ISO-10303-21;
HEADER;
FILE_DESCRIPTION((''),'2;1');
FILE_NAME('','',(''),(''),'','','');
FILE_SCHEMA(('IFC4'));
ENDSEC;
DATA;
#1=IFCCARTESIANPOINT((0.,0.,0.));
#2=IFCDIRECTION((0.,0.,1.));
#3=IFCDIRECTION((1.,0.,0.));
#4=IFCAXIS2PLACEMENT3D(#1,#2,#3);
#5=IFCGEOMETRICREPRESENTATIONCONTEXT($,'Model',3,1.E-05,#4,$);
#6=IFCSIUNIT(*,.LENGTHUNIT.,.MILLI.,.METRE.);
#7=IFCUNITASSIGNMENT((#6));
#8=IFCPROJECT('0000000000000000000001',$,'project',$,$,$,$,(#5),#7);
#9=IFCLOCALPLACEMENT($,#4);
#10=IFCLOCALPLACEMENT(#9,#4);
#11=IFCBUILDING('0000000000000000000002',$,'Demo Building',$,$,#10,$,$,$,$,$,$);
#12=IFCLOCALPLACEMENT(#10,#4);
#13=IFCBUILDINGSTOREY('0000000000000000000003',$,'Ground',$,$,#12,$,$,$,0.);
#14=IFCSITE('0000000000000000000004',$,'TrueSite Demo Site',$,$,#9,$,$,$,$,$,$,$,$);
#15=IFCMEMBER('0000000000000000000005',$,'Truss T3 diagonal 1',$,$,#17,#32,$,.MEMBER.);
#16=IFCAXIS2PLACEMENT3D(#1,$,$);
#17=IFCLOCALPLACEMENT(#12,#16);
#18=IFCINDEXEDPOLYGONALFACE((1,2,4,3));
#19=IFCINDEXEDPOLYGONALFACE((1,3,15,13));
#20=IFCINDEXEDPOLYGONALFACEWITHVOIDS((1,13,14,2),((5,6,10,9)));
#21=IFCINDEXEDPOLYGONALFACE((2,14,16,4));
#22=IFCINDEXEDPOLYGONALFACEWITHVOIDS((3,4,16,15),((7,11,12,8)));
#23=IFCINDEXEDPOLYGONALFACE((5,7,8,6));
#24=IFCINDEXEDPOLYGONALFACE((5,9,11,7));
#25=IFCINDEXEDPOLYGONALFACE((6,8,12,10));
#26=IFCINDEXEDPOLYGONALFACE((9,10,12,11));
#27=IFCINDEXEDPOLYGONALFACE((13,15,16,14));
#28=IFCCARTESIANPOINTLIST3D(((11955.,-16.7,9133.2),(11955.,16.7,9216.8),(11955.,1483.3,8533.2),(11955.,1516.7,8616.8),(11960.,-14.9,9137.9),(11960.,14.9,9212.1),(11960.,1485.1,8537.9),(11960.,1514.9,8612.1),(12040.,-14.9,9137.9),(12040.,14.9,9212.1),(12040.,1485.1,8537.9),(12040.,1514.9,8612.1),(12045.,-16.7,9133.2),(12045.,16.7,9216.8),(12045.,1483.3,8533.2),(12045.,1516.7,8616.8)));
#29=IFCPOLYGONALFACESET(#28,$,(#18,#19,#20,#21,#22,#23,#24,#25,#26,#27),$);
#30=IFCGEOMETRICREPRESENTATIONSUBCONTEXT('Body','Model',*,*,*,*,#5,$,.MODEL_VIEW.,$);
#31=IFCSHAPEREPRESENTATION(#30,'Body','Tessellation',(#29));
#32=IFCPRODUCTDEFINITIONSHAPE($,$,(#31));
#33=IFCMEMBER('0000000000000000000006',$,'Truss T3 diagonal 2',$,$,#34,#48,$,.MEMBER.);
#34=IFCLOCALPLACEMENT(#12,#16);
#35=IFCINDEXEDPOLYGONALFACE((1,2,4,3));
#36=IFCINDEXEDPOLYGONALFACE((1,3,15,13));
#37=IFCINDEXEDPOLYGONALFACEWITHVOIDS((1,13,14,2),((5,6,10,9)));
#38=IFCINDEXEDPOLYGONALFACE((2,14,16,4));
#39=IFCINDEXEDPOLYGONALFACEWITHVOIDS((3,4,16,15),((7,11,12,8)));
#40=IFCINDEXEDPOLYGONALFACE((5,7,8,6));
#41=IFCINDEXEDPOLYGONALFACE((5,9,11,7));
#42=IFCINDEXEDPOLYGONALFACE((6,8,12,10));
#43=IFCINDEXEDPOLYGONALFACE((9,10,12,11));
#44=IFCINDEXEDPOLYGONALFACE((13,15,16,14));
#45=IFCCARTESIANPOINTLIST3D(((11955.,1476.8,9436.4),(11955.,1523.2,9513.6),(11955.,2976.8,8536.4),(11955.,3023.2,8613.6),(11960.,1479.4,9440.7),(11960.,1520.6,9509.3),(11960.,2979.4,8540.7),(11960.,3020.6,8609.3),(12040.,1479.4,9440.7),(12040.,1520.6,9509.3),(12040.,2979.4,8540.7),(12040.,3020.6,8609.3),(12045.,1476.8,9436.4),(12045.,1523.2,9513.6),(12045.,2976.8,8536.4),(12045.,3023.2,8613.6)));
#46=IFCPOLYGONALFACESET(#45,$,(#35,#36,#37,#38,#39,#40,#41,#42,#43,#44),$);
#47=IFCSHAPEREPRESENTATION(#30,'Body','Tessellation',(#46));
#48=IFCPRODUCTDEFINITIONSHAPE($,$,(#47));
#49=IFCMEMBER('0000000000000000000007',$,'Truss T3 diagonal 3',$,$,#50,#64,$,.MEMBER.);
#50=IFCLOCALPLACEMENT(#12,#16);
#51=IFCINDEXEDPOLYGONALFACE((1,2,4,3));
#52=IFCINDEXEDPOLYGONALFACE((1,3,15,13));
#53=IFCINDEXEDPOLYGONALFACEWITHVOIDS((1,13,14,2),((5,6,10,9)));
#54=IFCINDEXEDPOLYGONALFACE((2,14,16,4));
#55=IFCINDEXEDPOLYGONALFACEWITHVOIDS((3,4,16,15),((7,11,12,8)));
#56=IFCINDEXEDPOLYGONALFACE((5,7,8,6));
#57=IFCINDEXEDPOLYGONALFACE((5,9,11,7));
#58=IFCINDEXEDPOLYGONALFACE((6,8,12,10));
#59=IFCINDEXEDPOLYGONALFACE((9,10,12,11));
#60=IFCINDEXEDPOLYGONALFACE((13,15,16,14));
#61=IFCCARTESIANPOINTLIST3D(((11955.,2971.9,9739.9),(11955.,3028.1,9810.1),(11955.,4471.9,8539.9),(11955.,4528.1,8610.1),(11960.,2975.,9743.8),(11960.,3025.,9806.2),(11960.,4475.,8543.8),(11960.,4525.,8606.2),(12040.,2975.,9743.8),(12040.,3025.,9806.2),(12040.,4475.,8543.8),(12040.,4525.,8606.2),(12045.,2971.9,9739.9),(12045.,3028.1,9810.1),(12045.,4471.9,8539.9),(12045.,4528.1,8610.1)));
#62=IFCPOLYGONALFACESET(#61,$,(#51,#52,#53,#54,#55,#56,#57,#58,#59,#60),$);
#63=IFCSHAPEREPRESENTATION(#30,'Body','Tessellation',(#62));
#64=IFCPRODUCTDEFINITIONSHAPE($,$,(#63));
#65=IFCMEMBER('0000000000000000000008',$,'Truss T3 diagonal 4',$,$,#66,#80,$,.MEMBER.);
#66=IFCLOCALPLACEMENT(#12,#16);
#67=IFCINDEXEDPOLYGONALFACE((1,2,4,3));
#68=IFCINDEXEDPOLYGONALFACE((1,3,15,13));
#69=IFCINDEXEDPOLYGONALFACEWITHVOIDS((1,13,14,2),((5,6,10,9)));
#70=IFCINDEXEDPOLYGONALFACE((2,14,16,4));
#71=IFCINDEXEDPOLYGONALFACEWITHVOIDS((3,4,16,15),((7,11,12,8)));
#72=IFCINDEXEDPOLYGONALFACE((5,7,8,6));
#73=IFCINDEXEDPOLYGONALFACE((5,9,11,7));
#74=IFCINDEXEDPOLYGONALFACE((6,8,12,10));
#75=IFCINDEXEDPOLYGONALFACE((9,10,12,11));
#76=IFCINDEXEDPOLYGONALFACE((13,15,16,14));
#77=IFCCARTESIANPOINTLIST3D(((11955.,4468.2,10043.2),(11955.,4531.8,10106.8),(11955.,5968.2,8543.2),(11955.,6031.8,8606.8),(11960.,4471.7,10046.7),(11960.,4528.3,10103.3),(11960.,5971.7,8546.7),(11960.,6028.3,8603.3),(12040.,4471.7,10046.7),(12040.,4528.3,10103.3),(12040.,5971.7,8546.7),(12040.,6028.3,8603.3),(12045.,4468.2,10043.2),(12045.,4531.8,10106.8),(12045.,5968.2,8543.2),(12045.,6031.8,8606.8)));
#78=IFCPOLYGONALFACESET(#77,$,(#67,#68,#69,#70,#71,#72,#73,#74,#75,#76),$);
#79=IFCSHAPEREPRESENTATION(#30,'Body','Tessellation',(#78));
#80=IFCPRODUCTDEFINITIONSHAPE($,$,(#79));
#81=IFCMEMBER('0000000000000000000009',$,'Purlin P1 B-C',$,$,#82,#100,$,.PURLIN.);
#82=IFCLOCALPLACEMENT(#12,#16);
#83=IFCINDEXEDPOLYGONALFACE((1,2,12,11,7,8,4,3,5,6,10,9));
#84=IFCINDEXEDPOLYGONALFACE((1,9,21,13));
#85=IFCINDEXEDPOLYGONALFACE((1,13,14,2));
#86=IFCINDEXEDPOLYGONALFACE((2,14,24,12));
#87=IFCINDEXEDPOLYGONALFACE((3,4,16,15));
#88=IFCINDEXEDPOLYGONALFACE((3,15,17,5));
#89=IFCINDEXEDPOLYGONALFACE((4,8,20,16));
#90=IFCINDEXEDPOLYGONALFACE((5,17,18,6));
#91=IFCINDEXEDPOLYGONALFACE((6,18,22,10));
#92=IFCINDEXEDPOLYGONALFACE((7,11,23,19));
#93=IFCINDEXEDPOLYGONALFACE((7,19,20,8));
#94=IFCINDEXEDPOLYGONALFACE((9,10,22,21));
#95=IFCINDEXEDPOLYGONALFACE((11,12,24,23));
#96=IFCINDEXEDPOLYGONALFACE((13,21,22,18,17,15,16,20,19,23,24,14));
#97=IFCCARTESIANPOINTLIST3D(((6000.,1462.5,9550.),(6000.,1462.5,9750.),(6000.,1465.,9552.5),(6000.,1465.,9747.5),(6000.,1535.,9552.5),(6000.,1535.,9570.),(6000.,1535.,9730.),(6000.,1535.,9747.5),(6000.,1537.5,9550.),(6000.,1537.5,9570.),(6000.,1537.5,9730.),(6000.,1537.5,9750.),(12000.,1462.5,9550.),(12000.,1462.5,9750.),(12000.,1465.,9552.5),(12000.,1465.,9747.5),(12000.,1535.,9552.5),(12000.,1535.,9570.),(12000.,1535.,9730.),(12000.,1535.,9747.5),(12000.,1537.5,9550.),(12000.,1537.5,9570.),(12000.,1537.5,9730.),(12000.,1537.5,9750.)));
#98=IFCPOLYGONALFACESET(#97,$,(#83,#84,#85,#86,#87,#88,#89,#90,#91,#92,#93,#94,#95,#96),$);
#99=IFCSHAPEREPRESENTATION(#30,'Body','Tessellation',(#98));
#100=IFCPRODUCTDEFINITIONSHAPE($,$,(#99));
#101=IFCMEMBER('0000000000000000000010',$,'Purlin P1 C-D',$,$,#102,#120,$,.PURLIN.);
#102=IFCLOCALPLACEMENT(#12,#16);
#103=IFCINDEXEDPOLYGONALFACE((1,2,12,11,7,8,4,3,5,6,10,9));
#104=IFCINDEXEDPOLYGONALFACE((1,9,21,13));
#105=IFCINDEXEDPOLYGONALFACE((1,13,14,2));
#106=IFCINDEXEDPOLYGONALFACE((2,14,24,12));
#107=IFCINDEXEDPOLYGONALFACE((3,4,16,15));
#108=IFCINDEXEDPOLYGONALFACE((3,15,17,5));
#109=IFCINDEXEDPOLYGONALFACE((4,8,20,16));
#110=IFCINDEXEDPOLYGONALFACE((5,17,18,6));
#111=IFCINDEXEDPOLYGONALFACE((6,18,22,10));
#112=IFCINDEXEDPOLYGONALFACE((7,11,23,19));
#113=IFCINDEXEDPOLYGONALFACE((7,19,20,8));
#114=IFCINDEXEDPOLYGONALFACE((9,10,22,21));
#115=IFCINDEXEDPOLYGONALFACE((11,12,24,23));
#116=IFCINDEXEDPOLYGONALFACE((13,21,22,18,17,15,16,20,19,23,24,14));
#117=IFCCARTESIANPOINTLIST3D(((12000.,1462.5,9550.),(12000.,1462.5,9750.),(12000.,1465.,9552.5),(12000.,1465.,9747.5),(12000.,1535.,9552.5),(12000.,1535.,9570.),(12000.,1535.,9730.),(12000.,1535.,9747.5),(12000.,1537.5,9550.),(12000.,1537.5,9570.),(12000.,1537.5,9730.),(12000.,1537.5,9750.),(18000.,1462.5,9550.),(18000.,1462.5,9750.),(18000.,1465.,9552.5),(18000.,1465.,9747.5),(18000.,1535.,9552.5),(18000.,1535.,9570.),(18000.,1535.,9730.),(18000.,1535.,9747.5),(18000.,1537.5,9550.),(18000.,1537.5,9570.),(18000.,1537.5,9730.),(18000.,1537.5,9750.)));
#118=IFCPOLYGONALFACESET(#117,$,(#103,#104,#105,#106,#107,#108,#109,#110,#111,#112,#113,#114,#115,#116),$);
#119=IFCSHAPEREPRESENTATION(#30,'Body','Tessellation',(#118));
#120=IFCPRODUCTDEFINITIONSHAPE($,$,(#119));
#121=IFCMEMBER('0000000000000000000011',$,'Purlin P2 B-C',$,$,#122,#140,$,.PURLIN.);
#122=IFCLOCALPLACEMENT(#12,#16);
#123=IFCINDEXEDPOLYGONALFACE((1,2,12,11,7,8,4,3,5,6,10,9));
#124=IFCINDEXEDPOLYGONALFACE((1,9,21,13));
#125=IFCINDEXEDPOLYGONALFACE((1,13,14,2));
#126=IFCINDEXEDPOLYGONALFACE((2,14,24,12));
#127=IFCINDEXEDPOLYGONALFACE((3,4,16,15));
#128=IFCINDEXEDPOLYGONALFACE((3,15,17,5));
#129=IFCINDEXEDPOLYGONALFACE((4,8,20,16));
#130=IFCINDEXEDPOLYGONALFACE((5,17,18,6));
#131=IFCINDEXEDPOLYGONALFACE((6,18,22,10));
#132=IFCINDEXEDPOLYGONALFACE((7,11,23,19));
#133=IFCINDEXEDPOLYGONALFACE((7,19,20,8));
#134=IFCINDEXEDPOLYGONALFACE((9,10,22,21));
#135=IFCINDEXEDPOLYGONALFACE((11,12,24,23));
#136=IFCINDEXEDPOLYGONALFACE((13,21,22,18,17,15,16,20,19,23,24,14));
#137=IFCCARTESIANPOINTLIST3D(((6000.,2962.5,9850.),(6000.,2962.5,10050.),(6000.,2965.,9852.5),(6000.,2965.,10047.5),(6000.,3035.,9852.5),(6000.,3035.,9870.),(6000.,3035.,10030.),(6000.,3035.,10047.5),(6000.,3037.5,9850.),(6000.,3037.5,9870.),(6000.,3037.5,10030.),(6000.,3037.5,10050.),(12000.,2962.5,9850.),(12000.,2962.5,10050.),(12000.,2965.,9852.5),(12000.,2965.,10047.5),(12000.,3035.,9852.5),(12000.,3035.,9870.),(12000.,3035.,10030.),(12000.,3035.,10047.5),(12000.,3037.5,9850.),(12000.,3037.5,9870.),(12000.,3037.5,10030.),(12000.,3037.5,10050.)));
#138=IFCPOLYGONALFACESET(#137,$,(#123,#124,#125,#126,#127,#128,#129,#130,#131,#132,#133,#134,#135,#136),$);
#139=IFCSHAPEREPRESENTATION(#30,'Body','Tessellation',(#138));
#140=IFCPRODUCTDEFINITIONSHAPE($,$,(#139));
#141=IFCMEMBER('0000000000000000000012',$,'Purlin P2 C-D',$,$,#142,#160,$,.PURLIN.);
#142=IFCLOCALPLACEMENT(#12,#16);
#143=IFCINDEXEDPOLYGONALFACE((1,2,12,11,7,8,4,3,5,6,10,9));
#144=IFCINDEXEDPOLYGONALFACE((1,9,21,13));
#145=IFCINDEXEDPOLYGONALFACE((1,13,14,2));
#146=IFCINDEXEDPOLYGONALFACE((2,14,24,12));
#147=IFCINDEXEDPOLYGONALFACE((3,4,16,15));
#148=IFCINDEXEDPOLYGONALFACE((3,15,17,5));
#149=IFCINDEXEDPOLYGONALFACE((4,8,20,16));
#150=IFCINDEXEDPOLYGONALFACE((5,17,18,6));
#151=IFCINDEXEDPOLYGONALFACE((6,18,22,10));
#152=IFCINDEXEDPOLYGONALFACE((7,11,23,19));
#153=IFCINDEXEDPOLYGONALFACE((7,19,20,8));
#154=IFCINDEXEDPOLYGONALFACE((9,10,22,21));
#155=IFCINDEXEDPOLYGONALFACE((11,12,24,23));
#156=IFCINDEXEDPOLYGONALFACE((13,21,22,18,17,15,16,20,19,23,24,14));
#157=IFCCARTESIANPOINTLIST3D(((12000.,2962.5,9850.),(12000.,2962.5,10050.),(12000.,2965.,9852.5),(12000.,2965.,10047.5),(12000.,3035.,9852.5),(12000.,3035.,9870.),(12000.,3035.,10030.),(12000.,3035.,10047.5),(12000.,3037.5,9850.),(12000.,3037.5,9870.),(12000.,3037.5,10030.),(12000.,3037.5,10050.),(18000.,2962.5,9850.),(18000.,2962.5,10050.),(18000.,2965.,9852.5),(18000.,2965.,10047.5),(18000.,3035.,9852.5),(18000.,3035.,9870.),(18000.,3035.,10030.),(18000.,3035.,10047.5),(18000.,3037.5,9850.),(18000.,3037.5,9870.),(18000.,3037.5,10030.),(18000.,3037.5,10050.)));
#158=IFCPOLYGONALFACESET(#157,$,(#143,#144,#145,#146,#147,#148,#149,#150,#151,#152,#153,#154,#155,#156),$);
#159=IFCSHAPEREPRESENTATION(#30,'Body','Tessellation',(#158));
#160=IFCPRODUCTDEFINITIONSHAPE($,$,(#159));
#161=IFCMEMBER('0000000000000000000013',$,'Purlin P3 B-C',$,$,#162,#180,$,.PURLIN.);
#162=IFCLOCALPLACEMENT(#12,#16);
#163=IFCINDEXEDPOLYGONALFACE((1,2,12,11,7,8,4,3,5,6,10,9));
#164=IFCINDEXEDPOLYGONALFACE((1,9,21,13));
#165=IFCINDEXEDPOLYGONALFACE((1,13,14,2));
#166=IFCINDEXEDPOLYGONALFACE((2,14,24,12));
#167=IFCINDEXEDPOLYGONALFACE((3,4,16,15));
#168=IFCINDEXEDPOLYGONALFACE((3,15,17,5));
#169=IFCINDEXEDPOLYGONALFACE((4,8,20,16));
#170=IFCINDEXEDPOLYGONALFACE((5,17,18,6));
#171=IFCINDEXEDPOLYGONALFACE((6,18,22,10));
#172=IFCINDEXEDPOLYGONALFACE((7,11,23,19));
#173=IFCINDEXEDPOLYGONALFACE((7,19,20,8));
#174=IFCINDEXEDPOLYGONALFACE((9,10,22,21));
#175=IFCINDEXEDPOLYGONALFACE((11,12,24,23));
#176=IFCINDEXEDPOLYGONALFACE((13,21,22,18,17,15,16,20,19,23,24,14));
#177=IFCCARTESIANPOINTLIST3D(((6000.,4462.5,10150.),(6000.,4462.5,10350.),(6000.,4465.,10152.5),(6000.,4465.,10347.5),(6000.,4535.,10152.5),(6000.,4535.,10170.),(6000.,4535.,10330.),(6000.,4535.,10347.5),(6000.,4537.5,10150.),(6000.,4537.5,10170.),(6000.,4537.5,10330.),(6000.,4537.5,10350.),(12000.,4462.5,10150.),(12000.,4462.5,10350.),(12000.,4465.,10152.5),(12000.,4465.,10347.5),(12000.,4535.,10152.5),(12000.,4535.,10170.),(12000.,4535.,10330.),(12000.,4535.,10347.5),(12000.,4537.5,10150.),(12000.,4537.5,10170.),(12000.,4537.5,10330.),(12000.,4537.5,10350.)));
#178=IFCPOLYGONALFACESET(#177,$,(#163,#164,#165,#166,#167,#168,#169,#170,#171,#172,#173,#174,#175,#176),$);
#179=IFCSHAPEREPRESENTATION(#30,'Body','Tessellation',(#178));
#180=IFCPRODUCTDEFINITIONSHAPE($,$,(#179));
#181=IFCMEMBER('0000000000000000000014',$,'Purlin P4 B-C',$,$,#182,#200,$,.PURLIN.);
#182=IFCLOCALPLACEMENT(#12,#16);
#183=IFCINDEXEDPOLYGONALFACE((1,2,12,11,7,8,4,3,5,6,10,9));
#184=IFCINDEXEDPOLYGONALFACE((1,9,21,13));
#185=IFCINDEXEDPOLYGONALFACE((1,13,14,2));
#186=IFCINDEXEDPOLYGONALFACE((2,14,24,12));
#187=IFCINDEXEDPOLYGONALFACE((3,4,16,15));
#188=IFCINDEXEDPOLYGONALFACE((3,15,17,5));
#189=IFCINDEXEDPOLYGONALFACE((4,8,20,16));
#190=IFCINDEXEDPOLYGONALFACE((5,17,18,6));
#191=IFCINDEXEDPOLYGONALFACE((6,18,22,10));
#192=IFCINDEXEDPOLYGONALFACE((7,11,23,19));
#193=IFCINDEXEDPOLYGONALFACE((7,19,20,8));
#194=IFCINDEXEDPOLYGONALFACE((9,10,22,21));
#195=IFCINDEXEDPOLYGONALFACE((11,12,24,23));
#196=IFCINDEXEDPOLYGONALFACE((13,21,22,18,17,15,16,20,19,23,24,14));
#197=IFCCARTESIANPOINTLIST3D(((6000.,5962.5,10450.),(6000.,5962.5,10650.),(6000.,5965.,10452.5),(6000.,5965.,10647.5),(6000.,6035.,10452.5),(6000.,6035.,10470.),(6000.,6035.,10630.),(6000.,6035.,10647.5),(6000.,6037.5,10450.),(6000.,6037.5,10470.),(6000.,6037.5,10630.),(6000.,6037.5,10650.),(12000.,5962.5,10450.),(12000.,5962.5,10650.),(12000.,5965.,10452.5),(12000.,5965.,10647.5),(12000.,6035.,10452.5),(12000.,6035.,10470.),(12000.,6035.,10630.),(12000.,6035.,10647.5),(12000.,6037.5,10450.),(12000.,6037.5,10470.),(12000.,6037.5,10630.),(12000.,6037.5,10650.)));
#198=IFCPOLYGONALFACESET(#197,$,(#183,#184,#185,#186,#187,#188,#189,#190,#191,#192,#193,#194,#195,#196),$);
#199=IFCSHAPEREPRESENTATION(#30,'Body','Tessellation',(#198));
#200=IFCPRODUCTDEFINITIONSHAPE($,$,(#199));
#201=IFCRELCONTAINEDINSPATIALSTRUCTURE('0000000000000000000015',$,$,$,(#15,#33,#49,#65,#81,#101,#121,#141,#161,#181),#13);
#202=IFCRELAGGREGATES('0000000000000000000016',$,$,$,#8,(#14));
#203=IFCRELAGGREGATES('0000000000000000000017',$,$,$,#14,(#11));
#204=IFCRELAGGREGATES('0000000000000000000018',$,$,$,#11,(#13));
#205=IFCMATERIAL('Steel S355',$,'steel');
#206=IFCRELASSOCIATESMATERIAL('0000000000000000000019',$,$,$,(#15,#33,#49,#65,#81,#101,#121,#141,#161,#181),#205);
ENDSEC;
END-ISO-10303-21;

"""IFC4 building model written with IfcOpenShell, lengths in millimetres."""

from ifc_helpers import new_model, si_unit, frame, origin_with_axes, place, context, subcontext, project, spatial, hollow_rectangle, c_section, extrude, material, element, save


model = new_model("IFC4")

# Units and contexts
model_context = context("Model", 3, precision=1e-05, world=origin_with_axes())
body_context = subcontext(model_context, "Body", "Model", "MODEL_VIEW")
ifc_project = project(units=[si_unit("LENGTHUNIT", "METRE", prefix="MILLI")], contexts=[model_context])

# Site, building, storey
site_placement = place(None, origin_with_axes())
site = spatial("IfcSite", under=ifc_project, at=site_placement, Name="TrueSite Demo Site")
building_placement = place(site_placement, origin_with_axes())
building = spatial("IfcBuilding", under=site, at=building_placement, Name="Demo Building")
storey_placement = place(building_placement, origin_with_axes())
storey = spatial("IfcBuildingStorey", under=building, at=storey_placement, Name="Ground", Elevation=0.0)

# Shared definitions
ifc_material_1 = material(Name="Steel S355", Category="steel")

# Members
member_1_placement = place(storey_placement, frame((12000.0, 0.0, 9175.0), z_axis=(0.0, 0.928477, -0.371391), x_axis=(-1.0, 0.0, 0.0)))
element("IfcMember", 1, at=member_1_placement, inside=storey, material=ifc_material_1, Name="Truss T3 diagonal 1", PredefinedType="MEMBER", context=body_context, shape_type="SweptSolid", body=[
    extrude(hollow_rectangle(XDim=90.0, YDim=90.0, WallThickness=5.0), origin_with_axes(), (0.0, 0.0, 1.0), 1615.5),
])
member_2_placement = place(storey_placement, frame((12000.0, 1500.0, 9475.0), z_axis=(0.0, 0.857493, -0.514496), x_axis=(-1.0, 0.0, 0.0)))
element("IfcMember", 2, at=member_2_placement, inside=storey, material=ifc_material_1, Name="Truss T3 diagonal 2", PredefinedType="MEMBER", context=body_context, shape_type="SweptSolid", body=[
    extrude(hollow_rectangle(XDim=90.0, YDim=90.0, WallThickness=5.0), origin_with_axes(), (0.0, 0.0, 1.0), 1749.3),
])
member_3_placement = place(storey_placement, frame((12000.0, 3000.0, 9775.0), z_axis=(0.0, 0.780869, -0.624695), x_axis=(-1.0, 0.0, 0.0)))
element("IfcMember", 3, at=member_3_placement, inside=storey, material=ifc_material_1, Name="Truss T3 diagonal 3", PredefinedType="MEMBER", context=body_context, shape_type="SweptSolid", body=[
    extrude(hollow_rectangle(XDim=90.0, YDim=90.0, WallThickness=5.0), origin_with_axes(), (0.0, 0.0, 1.0), 1920.9),
])
member_4_placement = place(storey_placement, frame((12000.0, 4500.0, 10075.0), z_axis=(0.0, 0.707107, -0.707107), x_axis=(-1.0, 0.0, 0.0)))
element("IfcMember", 4, at=member_4_placement, inside=storey, material=ifc_material_1, Name="Truss T3 diagonal 4", PredefinedType="MEMBER", context=body_context, shape_type="SweptSolid", body=[
    extrude(hollow_rectangle(XDim=90.0, YDim=90.0, WallThickness=5.0), origin_with_axes(), (0.0, 0.0, 1.0), 2121.3),
])
for number, where, z_axis, x_axis, name in (
    (5, (6000.0, 1500.0, 9650.0), (1.0, 0.0, 0.0), (0.0, 1.0, 0.0), "Purlin P1 B-C"),
    (6, (12000.0, 1500.0, 9650.0), (1.0, 0.0, 0.0), (0.0, 1.0, 0.0), "Purlin P1 C-D"),
    (7, (6000.0, 3000.0, 9950.0), (1.0, 0.0, 0.0), (0.0, 1.0, 0.0), "Purlin P2 B-C"),
    (8, (12000.0, 3000.0, 9950.0), (1.0, 0.0, 0.0), (0.0, 1.0, 0.0), "Purlin P2 C-D"),
    (9, (6000.0, 4500.0, 10250.0), (1.0, 0.0, 0.0), (0.0, 1.0, 0.0), "Purlin P3 B-C"),
    (10, (6000.0, 6000.0, 10550.0), (1.0, 0.0, 0.0), (0.0, 1.0, 0.0), "Purlin P4 B-C"),
):
    element("IfcMember", number, at=place(storey_placement, frame(where, z_axis=z_axis, x_axis=x_axis)), inside=storey, material=ifc_material_1, Name=name, PredefinedType="PURLIN", context=body_context, shape_type="SweptSolid", body=[
        extrude(c_section(Depth=200.0, Width=75.0, WallThickness=2.5, Girth=20.0), origin_with_axes(), (0.0, 0.0, 1.0), 6000.0),
    ])

save(model, "model.ifc")
